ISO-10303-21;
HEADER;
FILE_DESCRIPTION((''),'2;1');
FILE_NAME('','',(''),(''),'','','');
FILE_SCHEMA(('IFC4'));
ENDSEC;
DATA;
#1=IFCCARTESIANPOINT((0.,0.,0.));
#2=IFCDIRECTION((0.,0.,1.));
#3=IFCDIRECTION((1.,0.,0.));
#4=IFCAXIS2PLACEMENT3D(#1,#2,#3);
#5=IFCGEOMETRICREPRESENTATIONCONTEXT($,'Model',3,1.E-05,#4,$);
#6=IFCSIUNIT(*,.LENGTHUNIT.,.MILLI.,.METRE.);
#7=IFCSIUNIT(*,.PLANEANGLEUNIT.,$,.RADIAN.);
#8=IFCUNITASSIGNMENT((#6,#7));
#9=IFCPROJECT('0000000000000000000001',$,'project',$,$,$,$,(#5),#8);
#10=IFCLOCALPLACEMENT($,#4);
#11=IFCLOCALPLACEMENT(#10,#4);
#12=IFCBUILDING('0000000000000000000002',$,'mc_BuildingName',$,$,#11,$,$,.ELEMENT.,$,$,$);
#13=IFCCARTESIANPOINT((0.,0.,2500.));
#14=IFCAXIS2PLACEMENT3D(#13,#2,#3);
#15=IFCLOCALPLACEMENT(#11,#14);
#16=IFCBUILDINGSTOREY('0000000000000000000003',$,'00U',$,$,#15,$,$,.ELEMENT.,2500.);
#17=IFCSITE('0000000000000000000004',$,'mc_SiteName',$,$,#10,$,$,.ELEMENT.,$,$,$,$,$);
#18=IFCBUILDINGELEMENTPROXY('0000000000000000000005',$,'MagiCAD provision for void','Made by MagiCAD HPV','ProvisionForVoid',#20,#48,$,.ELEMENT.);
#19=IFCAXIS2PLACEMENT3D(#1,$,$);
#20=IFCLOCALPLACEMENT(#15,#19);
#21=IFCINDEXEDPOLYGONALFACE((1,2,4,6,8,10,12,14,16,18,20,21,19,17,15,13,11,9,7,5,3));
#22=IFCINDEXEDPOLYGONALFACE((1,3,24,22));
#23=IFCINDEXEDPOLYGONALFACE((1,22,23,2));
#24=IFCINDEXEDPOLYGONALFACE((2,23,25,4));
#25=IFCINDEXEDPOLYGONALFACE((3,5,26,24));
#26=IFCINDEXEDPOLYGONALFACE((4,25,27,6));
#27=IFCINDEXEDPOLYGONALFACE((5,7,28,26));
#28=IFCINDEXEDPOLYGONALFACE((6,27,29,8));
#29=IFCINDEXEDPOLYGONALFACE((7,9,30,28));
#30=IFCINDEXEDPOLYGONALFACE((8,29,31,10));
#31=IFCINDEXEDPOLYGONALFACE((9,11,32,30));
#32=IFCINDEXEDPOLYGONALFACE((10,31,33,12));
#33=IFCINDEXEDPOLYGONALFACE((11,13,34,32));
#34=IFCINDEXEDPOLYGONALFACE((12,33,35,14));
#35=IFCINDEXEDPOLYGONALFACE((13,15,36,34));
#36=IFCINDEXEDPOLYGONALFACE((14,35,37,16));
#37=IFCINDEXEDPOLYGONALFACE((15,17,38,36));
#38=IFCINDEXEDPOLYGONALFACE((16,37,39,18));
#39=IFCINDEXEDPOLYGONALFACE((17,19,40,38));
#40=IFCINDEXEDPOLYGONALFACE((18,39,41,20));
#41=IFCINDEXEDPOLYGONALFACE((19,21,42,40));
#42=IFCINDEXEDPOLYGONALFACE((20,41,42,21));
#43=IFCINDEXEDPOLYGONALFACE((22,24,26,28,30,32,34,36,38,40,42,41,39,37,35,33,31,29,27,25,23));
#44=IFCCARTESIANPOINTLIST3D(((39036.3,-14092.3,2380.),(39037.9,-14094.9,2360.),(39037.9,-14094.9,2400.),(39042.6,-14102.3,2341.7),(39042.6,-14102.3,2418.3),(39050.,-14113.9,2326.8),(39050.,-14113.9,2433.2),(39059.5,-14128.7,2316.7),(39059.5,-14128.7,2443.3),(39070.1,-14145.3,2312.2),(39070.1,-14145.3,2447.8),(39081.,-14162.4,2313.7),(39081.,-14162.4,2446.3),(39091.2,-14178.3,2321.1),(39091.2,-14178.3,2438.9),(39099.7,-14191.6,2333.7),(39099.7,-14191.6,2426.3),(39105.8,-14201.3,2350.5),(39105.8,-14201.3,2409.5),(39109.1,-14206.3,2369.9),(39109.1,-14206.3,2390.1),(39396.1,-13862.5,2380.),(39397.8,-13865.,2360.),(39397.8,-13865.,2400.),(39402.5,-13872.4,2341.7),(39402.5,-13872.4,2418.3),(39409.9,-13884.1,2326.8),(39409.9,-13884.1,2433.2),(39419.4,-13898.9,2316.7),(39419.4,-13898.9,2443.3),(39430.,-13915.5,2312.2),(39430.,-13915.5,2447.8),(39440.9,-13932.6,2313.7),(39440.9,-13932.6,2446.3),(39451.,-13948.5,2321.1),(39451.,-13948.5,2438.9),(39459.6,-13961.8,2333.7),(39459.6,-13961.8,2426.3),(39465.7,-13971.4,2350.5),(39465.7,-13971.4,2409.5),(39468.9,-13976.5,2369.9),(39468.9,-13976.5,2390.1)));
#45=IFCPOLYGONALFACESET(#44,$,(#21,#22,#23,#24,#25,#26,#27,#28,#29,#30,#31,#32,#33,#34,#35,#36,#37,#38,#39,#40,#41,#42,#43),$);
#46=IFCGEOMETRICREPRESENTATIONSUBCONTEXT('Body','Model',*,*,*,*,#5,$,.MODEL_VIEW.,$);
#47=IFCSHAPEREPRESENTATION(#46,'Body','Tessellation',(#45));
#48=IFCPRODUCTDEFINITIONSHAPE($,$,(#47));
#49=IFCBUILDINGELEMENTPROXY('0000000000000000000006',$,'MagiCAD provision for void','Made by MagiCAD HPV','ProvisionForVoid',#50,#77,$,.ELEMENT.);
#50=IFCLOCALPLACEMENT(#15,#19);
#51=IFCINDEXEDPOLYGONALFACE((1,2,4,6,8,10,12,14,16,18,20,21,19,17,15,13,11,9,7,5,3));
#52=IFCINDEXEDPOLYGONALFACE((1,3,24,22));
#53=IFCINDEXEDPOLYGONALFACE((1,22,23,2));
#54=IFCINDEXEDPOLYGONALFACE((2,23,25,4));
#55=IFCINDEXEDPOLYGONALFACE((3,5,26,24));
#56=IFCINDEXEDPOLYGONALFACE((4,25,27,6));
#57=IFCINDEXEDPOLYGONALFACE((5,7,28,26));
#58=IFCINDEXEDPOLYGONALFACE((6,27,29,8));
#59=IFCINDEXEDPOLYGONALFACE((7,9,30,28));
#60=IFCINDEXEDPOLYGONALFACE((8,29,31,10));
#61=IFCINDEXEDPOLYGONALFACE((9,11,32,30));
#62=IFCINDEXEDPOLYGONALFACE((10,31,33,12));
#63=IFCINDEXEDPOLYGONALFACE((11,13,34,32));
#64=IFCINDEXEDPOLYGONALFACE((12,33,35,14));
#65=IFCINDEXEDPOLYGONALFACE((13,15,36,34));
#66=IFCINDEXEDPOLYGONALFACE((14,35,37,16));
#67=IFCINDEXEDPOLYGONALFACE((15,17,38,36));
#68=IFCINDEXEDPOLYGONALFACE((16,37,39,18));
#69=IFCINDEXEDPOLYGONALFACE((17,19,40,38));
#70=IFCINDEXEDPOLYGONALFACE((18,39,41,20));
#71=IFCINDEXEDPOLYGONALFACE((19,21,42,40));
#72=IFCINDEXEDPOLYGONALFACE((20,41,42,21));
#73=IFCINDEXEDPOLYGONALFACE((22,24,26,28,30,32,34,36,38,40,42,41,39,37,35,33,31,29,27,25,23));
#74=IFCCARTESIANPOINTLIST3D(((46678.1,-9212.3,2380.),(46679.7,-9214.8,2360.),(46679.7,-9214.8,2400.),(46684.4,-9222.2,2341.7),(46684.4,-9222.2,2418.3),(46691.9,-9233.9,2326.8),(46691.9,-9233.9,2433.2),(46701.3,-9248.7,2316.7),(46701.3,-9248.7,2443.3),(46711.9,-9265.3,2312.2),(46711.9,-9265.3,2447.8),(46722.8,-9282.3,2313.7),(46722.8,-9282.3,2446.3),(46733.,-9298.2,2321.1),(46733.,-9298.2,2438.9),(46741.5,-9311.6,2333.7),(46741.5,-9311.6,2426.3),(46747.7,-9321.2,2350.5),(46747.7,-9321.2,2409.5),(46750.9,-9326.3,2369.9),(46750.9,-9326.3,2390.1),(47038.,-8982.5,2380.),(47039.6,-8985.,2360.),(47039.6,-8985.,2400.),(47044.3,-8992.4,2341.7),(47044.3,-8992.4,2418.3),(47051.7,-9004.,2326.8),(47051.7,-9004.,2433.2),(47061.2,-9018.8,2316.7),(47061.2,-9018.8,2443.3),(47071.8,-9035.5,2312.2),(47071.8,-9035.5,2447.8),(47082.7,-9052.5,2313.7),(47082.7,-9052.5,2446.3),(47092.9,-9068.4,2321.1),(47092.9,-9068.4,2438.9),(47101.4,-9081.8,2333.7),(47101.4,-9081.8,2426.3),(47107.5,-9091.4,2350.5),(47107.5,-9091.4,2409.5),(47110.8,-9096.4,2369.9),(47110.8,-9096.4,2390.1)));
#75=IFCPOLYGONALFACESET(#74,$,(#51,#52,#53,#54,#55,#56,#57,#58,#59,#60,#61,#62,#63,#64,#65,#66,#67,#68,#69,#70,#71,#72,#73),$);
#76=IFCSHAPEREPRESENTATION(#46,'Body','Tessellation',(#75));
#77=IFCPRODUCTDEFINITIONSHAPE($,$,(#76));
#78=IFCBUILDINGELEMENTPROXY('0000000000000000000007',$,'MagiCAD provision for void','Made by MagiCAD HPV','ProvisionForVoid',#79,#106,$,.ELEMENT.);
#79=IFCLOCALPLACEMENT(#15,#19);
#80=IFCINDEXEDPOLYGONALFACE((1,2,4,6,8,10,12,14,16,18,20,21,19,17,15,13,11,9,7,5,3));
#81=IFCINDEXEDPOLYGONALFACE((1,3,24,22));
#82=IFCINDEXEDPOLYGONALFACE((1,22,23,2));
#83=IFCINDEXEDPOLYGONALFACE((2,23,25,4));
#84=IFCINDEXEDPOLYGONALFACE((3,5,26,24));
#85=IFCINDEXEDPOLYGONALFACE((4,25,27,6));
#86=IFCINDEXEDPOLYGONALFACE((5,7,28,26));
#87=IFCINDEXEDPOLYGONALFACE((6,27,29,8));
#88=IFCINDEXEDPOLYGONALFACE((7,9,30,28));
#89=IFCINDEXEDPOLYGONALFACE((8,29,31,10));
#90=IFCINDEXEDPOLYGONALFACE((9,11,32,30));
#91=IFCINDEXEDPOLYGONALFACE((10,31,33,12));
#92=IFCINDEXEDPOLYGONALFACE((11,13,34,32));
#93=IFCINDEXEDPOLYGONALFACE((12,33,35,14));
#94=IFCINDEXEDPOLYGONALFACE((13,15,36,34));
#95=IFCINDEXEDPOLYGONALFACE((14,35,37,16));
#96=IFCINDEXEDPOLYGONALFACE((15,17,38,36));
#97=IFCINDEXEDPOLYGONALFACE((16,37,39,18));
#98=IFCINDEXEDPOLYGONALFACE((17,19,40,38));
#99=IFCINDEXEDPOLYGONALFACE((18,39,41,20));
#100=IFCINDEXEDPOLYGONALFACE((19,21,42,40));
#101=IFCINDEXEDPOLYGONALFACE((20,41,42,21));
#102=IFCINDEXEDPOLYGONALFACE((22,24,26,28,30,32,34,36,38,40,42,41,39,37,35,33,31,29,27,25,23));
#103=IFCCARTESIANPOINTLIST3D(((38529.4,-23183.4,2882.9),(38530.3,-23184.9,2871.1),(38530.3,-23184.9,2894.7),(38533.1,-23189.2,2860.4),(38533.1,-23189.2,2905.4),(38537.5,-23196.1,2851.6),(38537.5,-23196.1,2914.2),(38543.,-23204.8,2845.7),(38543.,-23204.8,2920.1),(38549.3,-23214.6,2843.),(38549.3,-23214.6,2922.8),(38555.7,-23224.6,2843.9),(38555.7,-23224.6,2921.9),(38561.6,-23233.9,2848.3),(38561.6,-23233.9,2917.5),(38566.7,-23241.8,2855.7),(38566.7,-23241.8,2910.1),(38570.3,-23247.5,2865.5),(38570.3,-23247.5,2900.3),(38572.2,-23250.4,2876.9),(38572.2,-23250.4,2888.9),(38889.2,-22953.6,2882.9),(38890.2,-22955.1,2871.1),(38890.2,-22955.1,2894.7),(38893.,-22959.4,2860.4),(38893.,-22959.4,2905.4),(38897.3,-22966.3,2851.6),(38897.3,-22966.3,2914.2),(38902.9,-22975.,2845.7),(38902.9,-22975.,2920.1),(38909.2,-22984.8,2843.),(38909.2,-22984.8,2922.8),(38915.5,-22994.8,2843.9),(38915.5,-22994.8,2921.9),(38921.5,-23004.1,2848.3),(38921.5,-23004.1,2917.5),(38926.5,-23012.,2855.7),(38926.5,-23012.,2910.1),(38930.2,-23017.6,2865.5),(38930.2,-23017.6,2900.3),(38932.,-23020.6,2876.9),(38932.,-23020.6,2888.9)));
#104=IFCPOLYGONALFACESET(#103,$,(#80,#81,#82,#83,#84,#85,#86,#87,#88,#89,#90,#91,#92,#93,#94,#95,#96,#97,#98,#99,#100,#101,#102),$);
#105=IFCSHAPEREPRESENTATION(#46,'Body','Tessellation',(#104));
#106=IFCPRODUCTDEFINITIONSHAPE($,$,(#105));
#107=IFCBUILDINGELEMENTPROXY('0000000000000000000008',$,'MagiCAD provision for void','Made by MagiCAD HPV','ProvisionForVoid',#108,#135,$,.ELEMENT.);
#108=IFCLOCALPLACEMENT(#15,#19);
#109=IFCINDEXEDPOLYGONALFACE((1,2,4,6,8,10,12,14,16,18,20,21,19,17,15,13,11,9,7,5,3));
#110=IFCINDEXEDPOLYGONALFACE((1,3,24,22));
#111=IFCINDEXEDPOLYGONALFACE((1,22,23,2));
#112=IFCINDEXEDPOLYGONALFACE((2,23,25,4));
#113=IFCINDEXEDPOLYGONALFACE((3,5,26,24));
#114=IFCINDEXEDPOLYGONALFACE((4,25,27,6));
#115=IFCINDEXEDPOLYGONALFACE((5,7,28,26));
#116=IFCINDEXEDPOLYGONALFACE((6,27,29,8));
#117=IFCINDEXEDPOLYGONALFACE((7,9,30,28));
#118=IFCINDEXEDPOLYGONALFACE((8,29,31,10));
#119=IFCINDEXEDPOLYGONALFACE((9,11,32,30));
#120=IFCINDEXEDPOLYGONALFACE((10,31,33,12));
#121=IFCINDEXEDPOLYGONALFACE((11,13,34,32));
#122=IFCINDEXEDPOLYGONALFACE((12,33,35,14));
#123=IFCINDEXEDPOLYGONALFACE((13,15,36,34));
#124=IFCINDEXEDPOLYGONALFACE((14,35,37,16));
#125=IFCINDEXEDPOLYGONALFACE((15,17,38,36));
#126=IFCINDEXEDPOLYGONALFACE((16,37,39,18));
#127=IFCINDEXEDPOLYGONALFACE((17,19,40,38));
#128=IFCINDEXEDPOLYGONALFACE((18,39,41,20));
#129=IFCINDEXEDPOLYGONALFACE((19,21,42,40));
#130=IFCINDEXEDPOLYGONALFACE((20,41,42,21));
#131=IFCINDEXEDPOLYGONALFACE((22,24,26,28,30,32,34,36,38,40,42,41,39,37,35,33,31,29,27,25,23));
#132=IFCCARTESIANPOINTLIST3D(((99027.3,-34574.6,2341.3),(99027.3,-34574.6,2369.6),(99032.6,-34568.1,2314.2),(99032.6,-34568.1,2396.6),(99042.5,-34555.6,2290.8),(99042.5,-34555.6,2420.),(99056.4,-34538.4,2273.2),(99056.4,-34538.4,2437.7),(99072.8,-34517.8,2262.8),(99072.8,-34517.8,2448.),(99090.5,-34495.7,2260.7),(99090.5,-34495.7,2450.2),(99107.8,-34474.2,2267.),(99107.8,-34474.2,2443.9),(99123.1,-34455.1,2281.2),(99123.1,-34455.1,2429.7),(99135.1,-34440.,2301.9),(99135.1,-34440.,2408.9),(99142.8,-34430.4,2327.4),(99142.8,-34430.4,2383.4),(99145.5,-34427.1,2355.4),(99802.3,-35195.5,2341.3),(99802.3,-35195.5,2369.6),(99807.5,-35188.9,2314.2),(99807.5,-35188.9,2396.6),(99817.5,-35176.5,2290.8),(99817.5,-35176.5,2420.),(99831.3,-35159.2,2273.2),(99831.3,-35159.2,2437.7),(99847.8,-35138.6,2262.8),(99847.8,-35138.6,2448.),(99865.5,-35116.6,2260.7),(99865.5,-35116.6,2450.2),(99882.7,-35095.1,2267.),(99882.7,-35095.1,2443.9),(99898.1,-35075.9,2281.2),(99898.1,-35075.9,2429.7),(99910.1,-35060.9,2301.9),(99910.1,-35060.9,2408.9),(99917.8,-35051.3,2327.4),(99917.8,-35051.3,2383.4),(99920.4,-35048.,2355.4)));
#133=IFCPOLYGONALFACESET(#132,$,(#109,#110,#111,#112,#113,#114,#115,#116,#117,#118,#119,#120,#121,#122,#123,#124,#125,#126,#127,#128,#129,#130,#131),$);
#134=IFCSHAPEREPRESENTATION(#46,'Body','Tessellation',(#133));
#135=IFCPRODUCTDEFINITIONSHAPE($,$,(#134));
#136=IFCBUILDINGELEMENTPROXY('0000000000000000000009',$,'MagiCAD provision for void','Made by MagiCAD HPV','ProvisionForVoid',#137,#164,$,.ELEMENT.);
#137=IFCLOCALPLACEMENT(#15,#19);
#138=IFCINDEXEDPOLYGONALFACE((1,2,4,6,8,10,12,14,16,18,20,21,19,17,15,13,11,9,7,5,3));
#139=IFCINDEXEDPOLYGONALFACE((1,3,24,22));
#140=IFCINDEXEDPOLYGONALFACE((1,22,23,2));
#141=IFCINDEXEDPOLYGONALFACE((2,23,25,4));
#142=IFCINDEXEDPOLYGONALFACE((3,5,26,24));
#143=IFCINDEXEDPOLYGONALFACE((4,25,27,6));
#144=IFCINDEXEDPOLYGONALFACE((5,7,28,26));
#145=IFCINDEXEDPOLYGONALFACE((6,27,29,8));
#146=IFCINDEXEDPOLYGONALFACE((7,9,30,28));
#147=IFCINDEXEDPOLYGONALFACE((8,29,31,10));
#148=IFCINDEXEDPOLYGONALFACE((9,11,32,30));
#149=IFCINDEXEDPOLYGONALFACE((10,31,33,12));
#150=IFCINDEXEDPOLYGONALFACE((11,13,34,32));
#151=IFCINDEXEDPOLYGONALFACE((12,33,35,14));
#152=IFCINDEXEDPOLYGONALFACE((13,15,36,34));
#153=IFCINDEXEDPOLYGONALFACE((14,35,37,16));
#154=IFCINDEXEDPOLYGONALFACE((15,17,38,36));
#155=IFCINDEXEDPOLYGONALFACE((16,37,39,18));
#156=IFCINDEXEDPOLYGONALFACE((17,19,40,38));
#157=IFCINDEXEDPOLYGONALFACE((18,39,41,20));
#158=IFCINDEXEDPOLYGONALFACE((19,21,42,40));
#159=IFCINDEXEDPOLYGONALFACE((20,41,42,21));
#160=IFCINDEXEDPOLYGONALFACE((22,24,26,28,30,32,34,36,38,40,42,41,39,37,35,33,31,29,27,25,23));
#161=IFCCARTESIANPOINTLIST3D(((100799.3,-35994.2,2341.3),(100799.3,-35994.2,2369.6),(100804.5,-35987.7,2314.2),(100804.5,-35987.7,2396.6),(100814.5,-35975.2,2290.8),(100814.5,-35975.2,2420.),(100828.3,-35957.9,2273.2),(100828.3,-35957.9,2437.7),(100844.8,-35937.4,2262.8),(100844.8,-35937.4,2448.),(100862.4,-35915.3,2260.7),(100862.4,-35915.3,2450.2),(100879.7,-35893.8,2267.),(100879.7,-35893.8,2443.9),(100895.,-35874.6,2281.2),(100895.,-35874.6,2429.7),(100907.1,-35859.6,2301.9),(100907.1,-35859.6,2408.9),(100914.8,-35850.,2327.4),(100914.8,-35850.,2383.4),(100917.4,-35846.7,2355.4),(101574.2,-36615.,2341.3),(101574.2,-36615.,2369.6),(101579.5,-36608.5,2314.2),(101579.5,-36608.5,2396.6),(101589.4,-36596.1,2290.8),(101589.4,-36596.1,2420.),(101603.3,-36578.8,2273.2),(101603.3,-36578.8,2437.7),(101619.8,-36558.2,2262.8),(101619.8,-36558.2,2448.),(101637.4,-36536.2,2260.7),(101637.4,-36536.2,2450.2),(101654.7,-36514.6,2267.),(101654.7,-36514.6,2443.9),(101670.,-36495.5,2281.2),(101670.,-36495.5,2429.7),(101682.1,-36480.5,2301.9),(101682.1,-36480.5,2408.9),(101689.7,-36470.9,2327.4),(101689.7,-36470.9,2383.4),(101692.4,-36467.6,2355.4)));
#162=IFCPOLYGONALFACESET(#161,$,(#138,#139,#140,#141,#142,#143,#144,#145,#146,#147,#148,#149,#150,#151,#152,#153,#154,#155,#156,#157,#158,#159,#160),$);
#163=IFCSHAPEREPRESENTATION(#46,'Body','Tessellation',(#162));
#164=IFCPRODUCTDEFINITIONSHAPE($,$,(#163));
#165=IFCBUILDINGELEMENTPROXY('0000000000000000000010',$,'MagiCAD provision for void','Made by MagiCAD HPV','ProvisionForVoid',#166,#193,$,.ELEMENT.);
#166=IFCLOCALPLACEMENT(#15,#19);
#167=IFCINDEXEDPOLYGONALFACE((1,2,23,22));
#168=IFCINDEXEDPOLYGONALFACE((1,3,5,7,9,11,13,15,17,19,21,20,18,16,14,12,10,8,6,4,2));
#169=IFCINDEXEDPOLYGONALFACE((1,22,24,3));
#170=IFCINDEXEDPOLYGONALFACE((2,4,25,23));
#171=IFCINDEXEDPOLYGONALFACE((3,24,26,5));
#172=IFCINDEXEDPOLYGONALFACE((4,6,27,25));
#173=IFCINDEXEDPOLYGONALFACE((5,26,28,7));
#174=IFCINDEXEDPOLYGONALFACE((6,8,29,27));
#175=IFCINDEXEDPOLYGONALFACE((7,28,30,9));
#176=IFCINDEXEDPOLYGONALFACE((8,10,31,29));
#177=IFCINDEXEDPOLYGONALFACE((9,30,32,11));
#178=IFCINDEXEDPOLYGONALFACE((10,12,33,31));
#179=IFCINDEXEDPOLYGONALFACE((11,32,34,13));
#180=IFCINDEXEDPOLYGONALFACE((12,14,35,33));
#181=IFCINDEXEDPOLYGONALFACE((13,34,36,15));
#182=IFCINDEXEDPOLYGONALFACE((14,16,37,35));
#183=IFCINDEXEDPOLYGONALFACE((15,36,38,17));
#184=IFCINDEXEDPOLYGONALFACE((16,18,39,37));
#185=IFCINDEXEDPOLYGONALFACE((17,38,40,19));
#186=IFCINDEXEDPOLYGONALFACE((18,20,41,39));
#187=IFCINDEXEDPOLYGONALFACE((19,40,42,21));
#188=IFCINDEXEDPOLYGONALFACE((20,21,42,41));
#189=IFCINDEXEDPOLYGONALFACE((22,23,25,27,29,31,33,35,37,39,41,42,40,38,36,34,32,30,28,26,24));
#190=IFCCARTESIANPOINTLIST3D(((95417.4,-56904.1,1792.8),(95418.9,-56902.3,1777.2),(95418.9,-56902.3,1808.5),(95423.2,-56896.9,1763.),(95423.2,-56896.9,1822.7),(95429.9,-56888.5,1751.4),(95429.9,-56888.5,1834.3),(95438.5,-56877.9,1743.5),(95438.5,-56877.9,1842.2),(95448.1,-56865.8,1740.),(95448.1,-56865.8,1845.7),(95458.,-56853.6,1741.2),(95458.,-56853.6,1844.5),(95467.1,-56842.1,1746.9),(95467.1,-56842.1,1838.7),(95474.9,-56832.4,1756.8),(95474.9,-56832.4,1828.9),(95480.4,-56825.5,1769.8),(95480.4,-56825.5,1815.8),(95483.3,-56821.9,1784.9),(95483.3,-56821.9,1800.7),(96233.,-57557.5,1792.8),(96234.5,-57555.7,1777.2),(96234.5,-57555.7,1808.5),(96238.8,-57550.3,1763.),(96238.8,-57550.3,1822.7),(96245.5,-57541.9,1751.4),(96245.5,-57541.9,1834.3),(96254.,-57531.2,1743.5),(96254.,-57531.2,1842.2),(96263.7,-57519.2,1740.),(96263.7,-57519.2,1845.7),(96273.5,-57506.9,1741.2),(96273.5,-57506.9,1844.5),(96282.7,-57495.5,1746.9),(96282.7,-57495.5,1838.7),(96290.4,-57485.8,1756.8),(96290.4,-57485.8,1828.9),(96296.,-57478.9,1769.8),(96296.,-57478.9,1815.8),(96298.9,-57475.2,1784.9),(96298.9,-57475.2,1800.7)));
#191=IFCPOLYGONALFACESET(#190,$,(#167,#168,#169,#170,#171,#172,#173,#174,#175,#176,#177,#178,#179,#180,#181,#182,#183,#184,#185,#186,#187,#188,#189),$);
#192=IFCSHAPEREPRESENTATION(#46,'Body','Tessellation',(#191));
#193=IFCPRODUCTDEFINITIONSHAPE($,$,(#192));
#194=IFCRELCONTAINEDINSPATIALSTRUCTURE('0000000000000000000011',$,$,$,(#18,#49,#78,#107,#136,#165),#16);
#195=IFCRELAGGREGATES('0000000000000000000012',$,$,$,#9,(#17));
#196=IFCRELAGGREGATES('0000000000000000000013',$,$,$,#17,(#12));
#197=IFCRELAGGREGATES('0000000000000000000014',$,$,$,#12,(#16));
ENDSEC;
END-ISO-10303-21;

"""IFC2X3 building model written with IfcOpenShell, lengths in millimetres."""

from ifc_helpers import new_model, si_unit, frame, origin_with_axes, origin_2d_with_axis, place, context, subcontext, project, spatial, circle, extrude, source, transform, mapped, element, save


model = new_model("IFC2X3")

# Units and contexts
model_context = context("Model", 3, precision=1e-05, world=origin_with_axes())
body_context = subcontext(model_context, "Body", "Model", "MODEL_VIEW")
ifc_project = project(units=[si_unit("LENGTHUNIT", "METRE", prefix="MILLI"), si_unit("PLANEANGLEUNIT", "RADIAN")], contexts=[model_context])

# Site, building, storey
site_placement = place(None, origin_with_axes())
site = spatial("IfcSite", under=ifc_project, at=site_placement, Name="mc_SiteName", CompositionType="ELEMENT")
building_placement = place(site_placement, origin_with_axes())
building = spatial("IfcBuilding", under=site, at=building_placement, Name="mc_BuildingName", CompositionType="ELEMENT")
storey_placement = place(building_placement, frame((0.0, 0.0, 2500.0), z_axis=(0.0, 0.0, 1.0), x_axis=(1.0, 0.0, 0.0)))
storey = spatial("IfcBuildingStorey", under=building, at=storey_placement, Name="00U", CompositionType="ELEMENT", Elevation=2500.0)

# Building element proxies
shared_shape_1 = source(origin_with_axes(), body_context, "Body", "SweptSolid", [
    extrude(circle(Radius=68.0, at=origin_2d_with_axis()), frame((0.0, 0.0, 0.0), z_axis=(1.0, 0.0, 0.0), x_axis=(0.0, 1.0, 0.0)), (0.0, 0.0, 1.0), 427.0),
])
proxy_1_placement = place(storey_placement, frame((39072.9, -14149.6, 2380.0), z_axis=(0.0, 0.0, 1.0), x_axis=(0.842809, 0.538213, 0.0)))
element("IfcBuildingElementProxy", 1, at=proxy_1_placement, inside=storey, Name="MagiCAD provision for void", Description="Made by MagiCAD HPV", ObjectType="ProvisionForVoid", CompositionType="ELEMENT", context=body_context, shape_type="MappedRepresentation", body=[
    mapped(shared_shape_1, transform((0.0, 0.0, 0.0), scale=1.0)),
])
shared_shape_2 = source(origin_with_axes(), body_context, "Body", "SweptSolid", [
    extrude(circle(Radius=68.0, at=origin_2d_with_axis()), frame((0.0, 0.0, 0.0), z_axis=(1.0, 0.0, 0.0), x_axis=(0.0, 1.0, 0.0)), (0.0, 0.0, 1.0), 427.0),
])
proxy_2_placement = place(storey_placement, frame((46714.7, -9269.6, 2380.0), z_axis=(0.0, 0.0, 1.0), x_axis=(0.842809, 0.538213, 0.0)))
element("IfcBuildingElementProxy", 2, at=proxy_2_placement, inside=storey, Name="MagiCAD provision for void", Description="Made by MagiCAD HPV", ObjectType="ProvisionForVoid", CompositionType="ELEMENT", context=body_context, shape_type="MappedRepresentation", body=[
    mapped(shared_shape_2, transform((0.0, 0.0, 0.0), scale=1.0)),
])
shared_shape_3 = source(origin_with_axes(), body_context, "Body", "SweptSolid", [
    extrude(circle(Radius=40.0, at=origin_2d_with_axis()), frame((0.0, 0.0, 0.0), z_axis=(1.0, 0.0, 0.0), x_axis=(0.0, 1.0, 0.0)), (0.0, 0.0, 1.0), 427.0),
])
proxy_3_placement = place(storey_placement, frame((38550.9, -23217.1, 2882.9), z_axis=(0.0, 0.0, 1.0), x_axis=(0.842809, 0.538213, 0.0)))
element("IfcBuildingElementProxy", 3, at=proxy_3_placement, inside=storey, Name="MagiCAD provision for void", Description="Made by MagiCAD HPV", ObjectType="ProvisionForVoid", CompositionType="ELEMENT", context=body_context, shape_type="MappedRepresentation", body=[
    mapped(shared_shape_3, transform((0.0, 0.0, 0.0), scale=1.0)),
])
shared_shape_4 = source(origin_with_axes(), body_context, "Body", "SweptSolid", [
    extrude(circle(Radius=95.0, at=origin_2d_with_axis()), frame((0.0, 0.0, 0.0), z_axis=(1.0, 0.0, 0.0), x_axis=(0.0, 1.0, 0.0)), (0.0, 0.0, 1.0), 993.0),
])
proxy_4_placement = place(storey_placement, frame((99086.1, -34501.3, 2355.4), z_axis=(0.0, 0.0, 1.0), x_axis=(0.780434, -0.625238, 0.0)))
element("IfcBuildingElementProxy", 4, at=proxy_4_placement, inside=storey, Name="MagiCAD provision for void", Description="Made by MagiCAD HPV", ObjectType="ProvisionForVoid", CompositionType="ELEMENT", context=body_context, shape_type="MappedRepresentation", body=[
    mapped(shared_shape_4, transform((0.0, 0.0, 0.0), scale=1.0)),
])
shared_shape_5 = source(origin_with_axes(), body_context, "Body", "SweptSolid", [
    extrude(circle(Radius=95.0, at=origin_2d_with_axis()), frame((0.0, 0.0, 0.0), z_axis=(1.0, 0.0, 0.0), x_axis=(0.0, 1.0, 0.0)), (0.0, 0.0, 1.0), 993.0),
])
proxy_5_placement = place(storey_placement, frame((100858.0, -35920.9, 2355.4), z_axis=(0.0, 0.0, 1.0), x_axis=(0.780434, -0.625238, 0.0)))
element("IfcBuildingElementProxy", 5, at=proxy_5_placement, inside=storey, Name="MagiCAD provision for void", Description="Made by MagiCAD HPV", ObjectType="ProvisionForVoid", CompositionType="ELEMENT", context=body_context, shape_type="MappedRepresentation", body=[
    mapped(shared_shape_5, transform((0.0, 0.0, 0.0), scale=1.0)),
])
shared_shape_6 = source(origin_with_axes(), body_context, "Body", "SweptSolid", [
    extrude(circle(Radius=53.0, at=origin_2d_with_axis()), frame((0.0, 0.0, 0.0), z_axis=(1.0, 0.0, 0.0), x_axis=(0.0, 1.0, 0.0)), (0.0, 0.0, 1.0), 1045.0),
])
proxy_6_placement = place(storey_placement, frame((96266.1, -57516.1, 1792.8), z_axis=(0.0, 0.0, 1.0), x_axis=(-0.780434, 0.625238, 0.0)))
element("IfcBuildingElementProxy", 6, at=proxy_6_placement, inside=storey, Name="MagiCAD provision for void", Description="Made by MagiCAD HPV", ObjectType="ProvisionForVoid", CompositionType="ELEMENT", context=body_context, shape_type="MappedRepresentation", body=[
    mapped(shared_shape_6, transform((0.0, 0.0, 0.0), scale=1.0)),
])

save(model, "model.ifc")
